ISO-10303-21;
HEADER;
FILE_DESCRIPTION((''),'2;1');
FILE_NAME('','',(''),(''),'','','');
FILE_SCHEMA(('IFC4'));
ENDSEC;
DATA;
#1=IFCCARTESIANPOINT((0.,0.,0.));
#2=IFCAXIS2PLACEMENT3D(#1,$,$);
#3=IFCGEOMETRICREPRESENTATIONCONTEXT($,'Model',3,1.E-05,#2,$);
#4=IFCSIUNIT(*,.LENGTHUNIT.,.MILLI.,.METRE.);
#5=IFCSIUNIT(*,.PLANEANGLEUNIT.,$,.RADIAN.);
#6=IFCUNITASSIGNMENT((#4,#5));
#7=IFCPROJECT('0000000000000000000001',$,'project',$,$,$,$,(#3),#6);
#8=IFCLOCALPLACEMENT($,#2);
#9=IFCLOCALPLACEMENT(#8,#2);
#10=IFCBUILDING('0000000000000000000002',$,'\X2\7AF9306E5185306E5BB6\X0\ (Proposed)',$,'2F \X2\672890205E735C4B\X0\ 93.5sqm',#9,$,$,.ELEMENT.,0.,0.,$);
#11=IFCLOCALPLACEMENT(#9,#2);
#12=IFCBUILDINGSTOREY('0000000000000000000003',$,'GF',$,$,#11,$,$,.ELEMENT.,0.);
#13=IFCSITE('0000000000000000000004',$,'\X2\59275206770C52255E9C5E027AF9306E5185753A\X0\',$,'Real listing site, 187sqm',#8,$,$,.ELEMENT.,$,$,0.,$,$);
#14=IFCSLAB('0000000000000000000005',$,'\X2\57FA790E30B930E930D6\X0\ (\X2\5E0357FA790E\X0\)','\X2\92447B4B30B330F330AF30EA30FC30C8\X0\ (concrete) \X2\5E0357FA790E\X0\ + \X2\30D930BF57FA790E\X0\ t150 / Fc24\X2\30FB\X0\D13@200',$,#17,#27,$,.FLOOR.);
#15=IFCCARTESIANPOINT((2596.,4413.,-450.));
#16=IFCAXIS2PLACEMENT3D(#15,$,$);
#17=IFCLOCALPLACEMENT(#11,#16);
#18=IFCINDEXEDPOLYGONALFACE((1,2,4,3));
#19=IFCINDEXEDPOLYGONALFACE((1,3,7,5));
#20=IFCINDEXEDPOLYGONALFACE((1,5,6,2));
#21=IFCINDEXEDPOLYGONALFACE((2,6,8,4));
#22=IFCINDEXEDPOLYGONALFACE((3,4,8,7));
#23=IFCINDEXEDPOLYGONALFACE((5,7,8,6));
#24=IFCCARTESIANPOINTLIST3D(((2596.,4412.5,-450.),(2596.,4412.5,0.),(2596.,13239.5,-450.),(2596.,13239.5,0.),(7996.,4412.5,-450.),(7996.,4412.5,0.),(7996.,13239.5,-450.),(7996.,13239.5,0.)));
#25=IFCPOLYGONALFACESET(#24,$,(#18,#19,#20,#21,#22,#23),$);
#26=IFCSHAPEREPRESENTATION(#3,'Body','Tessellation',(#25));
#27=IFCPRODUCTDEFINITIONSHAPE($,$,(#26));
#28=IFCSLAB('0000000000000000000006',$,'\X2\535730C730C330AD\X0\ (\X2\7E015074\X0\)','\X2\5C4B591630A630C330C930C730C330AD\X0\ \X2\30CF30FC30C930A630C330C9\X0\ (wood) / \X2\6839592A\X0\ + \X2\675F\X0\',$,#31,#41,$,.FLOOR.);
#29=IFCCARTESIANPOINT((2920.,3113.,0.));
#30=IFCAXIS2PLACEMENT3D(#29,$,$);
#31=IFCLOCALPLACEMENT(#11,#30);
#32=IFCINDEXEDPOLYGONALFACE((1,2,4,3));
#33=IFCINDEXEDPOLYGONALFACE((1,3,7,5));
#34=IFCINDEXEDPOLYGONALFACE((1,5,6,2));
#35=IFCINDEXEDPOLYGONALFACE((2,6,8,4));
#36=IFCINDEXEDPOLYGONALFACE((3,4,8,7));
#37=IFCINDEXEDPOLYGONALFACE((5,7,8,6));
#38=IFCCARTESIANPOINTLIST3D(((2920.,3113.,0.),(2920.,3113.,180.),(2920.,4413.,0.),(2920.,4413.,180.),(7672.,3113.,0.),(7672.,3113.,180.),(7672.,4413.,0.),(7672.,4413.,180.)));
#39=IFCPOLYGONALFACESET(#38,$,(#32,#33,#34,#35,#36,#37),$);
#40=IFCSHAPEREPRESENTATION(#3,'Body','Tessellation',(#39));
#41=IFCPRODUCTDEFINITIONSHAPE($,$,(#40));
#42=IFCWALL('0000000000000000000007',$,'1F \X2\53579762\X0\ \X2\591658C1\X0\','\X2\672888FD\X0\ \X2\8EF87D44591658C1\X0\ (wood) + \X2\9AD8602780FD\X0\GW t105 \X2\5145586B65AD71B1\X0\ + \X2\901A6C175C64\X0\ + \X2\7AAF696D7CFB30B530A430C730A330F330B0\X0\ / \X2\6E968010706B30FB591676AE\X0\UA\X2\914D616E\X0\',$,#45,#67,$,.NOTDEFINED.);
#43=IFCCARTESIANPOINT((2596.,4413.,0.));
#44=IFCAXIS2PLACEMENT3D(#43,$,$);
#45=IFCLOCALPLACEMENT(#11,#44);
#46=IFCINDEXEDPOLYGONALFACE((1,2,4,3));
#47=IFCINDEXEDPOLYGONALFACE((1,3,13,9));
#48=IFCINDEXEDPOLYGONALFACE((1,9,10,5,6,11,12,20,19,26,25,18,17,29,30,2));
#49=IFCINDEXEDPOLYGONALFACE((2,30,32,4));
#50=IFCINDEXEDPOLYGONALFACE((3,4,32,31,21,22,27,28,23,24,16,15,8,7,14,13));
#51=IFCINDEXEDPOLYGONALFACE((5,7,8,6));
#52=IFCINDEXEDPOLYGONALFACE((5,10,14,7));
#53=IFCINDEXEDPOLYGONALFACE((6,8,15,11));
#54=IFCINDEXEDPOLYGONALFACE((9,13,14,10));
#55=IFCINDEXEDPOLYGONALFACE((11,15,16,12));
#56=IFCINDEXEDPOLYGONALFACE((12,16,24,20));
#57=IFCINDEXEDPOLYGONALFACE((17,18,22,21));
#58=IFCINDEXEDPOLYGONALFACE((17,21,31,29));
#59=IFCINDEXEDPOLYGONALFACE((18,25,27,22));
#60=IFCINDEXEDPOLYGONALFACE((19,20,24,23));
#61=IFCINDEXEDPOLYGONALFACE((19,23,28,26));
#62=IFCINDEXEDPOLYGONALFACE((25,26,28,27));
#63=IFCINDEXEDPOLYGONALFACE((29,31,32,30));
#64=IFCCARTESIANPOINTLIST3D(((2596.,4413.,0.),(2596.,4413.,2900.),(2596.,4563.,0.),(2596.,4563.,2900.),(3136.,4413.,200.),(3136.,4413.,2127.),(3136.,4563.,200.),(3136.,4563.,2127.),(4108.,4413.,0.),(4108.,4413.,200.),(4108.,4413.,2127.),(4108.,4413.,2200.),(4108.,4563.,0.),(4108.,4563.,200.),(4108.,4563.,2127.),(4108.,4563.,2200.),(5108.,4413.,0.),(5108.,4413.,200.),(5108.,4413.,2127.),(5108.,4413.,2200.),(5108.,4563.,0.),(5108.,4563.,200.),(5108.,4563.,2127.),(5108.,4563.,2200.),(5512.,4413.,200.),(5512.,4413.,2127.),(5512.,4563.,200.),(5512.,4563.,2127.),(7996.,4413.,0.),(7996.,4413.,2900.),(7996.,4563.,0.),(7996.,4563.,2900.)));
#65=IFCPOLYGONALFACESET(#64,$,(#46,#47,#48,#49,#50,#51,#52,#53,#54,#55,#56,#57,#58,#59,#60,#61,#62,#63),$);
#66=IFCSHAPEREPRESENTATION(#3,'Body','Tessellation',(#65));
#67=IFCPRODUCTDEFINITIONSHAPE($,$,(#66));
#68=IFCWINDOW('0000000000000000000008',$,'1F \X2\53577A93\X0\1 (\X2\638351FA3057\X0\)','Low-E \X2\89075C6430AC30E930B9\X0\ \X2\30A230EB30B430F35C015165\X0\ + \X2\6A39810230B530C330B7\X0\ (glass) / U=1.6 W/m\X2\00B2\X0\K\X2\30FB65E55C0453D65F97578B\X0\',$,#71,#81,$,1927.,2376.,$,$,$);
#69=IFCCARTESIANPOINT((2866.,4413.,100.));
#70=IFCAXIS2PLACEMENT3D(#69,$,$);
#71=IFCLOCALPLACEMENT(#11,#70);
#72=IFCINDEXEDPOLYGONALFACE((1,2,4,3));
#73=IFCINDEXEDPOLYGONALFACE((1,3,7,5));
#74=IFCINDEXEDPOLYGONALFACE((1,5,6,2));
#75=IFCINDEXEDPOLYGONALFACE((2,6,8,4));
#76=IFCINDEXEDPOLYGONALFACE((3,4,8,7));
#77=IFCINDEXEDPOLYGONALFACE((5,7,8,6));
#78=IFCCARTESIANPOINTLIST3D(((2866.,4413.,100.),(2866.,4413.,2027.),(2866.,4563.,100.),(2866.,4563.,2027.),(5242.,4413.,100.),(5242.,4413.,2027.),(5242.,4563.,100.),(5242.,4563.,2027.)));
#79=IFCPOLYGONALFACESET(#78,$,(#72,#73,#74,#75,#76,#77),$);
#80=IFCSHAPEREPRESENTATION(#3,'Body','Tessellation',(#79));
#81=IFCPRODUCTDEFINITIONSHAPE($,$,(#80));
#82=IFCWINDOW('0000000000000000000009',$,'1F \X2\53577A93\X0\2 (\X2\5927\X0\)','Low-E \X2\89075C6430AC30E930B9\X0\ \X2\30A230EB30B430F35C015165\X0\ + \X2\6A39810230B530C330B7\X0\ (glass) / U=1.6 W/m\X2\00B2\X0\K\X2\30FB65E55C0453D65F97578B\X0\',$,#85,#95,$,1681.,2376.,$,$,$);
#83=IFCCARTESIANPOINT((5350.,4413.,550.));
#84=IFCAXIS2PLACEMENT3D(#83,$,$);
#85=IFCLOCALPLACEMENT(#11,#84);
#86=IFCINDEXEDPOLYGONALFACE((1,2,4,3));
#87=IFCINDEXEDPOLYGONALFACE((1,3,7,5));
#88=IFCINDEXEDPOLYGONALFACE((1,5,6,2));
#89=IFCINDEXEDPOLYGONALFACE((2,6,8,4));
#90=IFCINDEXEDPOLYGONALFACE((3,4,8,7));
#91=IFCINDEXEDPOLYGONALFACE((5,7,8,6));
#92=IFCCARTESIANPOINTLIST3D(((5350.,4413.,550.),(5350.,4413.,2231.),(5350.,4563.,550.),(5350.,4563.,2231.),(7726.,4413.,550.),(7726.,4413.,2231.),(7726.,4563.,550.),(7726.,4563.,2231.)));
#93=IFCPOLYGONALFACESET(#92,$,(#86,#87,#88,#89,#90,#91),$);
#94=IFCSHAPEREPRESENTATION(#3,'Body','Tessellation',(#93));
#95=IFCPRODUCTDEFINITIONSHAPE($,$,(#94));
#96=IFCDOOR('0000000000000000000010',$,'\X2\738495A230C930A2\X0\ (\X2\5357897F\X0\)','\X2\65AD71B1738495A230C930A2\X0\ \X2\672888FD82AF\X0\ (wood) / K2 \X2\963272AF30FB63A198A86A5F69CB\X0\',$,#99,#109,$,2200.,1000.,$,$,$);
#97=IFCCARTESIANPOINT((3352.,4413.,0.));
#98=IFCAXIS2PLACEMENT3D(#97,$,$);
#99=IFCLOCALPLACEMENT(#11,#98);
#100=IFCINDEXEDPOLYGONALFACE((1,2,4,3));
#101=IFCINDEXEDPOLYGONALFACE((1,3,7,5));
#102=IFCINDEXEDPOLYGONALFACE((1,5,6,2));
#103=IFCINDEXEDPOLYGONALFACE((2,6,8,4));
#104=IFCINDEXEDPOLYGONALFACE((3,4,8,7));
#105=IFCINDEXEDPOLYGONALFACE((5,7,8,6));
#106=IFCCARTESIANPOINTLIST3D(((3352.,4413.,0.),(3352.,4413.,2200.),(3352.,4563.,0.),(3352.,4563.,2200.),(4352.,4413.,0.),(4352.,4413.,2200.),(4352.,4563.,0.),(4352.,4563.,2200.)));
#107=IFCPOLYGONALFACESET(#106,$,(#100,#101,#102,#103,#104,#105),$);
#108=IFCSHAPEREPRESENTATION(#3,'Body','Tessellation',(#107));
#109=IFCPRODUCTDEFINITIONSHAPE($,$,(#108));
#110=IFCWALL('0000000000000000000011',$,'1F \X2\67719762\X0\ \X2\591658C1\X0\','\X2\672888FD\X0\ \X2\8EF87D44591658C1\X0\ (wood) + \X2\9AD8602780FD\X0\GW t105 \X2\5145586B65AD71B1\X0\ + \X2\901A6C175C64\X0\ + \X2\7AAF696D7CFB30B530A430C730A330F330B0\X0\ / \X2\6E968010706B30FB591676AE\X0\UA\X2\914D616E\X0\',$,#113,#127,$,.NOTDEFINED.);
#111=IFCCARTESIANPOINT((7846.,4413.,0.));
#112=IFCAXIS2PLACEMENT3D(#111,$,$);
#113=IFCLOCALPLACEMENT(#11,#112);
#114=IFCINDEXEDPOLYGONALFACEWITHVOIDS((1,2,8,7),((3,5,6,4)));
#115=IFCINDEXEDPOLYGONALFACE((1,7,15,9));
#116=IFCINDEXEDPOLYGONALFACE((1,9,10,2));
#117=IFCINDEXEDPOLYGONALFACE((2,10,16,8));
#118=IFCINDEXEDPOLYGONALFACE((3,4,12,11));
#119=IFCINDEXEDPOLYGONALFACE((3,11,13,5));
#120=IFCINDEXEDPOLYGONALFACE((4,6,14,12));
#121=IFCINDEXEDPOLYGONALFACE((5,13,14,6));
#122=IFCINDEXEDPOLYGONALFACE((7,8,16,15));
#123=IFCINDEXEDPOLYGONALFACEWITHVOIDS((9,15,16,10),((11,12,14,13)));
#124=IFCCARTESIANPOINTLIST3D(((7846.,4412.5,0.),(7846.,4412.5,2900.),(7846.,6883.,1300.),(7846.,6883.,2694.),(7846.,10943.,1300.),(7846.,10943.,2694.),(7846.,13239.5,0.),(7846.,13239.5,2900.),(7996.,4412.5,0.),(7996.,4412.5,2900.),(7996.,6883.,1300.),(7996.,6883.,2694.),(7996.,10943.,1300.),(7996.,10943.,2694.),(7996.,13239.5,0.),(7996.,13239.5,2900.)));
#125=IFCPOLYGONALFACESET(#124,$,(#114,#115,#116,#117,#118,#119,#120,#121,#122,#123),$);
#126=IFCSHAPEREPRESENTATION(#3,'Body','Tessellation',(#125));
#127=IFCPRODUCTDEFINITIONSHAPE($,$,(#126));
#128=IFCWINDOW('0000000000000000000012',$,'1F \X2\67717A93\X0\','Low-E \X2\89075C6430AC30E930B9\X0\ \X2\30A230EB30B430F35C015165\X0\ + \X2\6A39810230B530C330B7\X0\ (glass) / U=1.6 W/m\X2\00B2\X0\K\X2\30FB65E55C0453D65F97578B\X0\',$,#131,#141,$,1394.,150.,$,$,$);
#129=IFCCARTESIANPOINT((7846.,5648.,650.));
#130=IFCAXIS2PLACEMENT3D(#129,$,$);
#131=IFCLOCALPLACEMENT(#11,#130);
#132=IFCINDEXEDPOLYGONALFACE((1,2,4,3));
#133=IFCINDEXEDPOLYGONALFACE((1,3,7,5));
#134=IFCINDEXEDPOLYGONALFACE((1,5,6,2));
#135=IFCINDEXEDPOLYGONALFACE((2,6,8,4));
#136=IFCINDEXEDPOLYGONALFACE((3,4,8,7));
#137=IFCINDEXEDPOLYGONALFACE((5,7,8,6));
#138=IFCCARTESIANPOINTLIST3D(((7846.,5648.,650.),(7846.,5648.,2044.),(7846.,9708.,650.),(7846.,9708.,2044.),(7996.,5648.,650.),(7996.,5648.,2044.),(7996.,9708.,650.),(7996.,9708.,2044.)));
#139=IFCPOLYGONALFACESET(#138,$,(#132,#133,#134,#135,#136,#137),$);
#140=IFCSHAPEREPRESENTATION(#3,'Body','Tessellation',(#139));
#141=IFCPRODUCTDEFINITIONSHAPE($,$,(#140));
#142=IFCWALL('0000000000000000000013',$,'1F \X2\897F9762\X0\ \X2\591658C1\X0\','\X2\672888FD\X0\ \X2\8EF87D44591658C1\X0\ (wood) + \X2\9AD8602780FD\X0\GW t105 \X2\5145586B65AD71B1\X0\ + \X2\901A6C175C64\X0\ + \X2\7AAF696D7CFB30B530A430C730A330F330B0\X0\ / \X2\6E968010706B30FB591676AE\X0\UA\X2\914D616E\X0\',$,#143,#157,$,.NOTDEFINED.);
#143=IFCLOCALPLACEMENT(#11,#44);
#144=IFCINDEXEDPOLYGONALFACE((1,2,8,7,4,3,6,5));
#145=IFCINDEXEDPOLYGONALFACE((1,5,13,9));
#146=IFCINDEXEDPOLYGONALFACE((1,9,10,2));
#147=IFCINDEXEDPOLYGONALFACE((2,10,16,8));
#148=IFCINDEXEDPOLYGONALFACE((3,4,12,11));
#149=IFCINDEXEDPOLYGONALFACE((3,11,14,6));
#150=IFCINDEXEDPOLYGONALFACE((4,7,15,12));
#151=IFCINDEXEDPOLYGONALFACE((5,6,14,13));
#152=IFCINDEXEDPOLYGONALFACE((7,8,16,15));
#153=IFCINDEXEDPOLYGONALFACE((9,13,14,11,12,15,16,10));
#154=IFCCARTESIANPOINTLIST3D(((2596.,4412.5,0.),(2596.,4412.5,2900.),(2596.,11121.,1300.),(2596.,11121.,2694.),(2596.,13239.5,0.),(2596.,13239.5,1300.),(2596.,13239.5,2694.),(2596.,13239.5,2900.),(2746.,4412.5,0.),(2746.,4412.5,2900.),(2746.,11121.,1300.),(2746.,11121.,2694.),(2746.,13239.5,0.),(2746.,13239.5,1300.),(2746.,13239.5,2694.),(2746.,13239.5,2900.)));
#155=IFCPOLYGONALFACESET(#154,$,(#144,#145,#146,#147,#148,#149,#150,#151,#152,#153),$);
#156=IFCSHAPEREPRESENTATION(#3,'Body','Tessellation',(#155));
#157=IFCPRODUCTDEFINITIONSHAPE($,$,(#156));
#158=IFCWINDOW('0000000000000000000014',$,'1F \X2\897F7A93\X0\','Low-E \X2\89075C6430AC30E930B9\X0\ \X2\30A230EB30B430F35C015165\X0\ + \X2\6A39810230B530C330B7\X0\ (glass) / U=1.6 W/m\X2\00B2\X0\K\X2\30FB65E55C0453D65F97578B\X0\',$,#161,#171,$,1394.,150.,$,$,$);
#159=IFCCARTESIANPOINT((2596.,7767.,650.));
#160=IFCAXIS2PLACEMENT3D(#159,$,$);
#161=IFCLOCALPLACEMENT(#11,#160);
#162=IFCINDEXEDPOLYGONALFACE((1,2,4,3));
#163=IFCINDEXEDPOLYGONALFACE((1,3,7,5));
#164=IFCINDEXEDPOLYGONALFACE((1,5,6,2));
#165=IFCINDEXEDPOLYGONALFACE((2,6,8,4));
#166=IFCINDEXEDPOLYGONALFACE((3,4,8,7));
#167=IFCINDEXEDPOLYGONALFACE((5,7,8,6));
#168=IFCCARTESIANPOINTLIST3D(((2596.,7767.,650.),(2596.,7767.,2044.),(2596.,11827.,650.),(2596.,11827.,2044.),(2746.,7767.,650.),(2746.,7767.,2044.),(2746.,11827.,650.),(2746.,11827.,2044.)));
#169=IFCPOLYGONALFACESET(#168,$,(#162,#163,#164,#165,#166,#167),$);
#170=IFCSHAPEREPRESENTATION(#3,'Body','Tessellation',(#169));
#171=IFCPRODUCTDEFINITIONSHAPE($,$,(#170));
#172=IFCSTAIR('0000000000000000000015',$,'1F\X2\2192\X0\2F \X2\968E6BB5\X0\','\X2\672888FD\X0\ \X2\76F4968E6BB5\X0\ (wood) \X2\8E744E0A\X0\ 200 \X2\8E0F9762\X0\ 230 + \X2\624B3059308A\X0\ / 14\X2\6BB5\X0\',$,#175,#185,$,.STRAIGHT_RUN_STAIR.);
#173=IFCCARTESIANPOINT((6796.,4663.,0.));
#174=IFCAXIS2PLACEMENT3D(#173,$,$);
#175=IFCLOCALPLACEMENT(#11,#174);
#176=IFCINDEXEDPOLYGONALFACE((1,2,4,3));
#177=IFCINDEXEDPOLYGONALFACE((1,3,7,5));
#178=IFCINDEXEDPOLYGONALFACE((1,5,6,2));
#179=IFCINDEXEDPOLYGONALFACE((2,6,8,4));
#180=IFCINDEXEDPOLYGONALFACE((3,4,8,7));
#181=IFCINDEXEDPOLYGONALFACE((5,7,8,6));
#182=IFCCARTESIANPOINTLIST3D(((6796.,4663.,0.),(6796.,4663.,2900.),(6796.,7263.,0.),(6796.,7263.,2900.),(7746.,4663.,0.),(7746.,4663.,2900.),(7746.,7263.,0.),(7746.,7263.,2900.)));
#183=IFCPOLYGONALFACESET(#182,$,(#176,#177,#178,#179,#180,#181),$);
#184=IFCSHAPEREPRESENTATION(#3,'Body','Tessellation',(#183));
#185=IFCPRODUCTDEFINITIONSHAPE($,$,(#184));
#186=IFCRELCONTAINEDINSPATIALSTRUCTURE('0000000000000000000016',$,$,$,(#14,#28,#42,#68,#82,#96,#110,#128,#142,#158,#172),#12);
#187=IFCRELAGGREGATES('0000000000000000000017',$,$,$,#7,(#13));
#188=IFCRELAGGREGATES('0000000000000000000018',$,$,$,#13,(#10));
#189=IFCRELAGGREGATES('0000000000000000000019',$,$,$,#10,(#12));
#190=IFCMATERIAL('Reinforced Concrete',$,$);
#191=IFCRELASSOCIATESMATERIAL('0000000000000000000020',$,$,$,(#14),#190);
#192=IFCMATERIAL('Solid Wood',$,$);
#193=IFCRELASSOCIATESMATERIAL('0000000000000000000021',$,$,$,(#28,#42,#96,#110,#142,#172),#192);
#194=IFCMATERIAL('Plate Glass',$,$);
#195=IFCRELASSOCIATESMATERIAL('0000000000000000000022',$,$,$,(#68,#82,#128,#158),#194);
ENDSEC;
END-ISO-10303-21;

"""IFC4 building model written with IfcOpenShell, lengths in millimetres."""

from ifc_helpers import new_model, si_unit, frame, frame_2d, origin, place, context, project, spatial, rectangle, extrude, material, element, fill, save


model = new_model("IFC4")

# Units and contexts
model_context = context("Model", 3, precision=1e-05, world=origin())
ifc_project = project(units=[si_unit("LENGTHUNIT", "METRE", prefix="MILLI"), si_unit("PLANEANGLEUNIT", "RADIAN")], contexts=[model_context])

# Site, building, storey
site_placement = place(None, origin())
site = spatial("IfcSite", under=ifc_project, at=site_placement, Name="大分県別府市竹の内町", ObjectType="Real listing site, 187sqm", CompositionType="ELEMENT", RefElevation=0.0)
building_placement = place(site_placement, origin())
building = spatial("IfcBuilding", under=site, at=building_placement, Name="竹の内の家 (Proposed)", ObjectType="2F 木造平屋 93.5sqm", CompositionType="ELEMENT", ElevationOfRefHeight=0.0, ElevationOfTerrain=0.0)
storey_placement = place(building_placement, origin())
storey = spatial("IfcBuildingStorey", under=building, at=storey_placement, Name="GF", CompositionType="ELEMENT", Elevation=0.0)

# Slabs
ifc_material_1 = material(Name="Reinforced Concrete")
slab_1_placement = place(storey_placement, frame((2596.0, 4413.0, -450.0)))
element("IfcSlab", 1, at=slab_1_placement, inside=storey, material=ifc_material_1, Name="基礎スラブ (布基礎)", Description="鉄筋コンクリート (concrete) 布基礎 + ベタ基礎 t150 / Fc24・D13@200", PredefinedType="FLOOR", context=model_context, shape_type="SweptSolid", body=[
    extrude(rectangle(XDim=5400.0, YDim=8827.0, at=frame_2d((2700.0, 4413.0))), frame((2596.0, 4413.0, -450.0)), (0.0, 0.0, 1.0), 450.0),
])
ifc_material_2 = material(Name="Solid Wood")
slab_2_placement = place(storey_placement, frame((2920.0, 3113.0, 0.0)))
element("IfcSlab", 2, at=slab_2_placement, inside=storey, material=ifc_material_2, Name="南デッキ (縁側)", Description="屋外ウッドデッキ ハードウッド (wood) / 根太 + 束", PredefinedType="FLOOR", context=model_context, shape_type="SweptSolid", body=[
    extrude(rectangle(XDim=4752.0, YDim=1300.0, at=frame_2d((2376.0, 650.0))), frame((2920.0, 3113.0, 0.0)), (0.0, 0.0, 1.0), 180.0),
])

# Wall, openings, windows, door
wall_1_placement = place(storey_placement, frame((2596.0, 4413.0, 0.0)))
wall_1 = element("IfcWall", 3, at=wall_1_placement, inside=storey, material=ifc_material_2, Name="1F 南面 外壁", Description="木製 軸組外壁 (wood) + 高性能GW t105 充填断熱 + 通気層 + 窯業系サイディング / 準耐火・外皮UA配慮", PredefinedType="NOTDEFINED", context=model_context, shape_type="SweptSolid", body=[
    extrude(rectangle(XDim=5400.0, YDim=150.0, at=frame_2d((2700.0, 75.0))), frame((2596.0, 4413.0, 0.0)), (0.0, 0.0, 1.0), 2900.0),
])
opening_1_placement = place(storey_placement, frame((2866.0, 4413.0, 100.0)))
opening_1 = element("IfcOpeningElement", 4, at=opening_1_placement, cuts=wall_1, PredefinedType="NOTDEFINED", context=model_context, shape_type="SweptSolid", body=[
    extrude(rectangle(XDim=2376.0, YDim=150.0, at=frame_2d((1188.0, 75.0))), frame((2866.0, 4413.0, 100.0)), (0.0, 0.0, 1.0), 1927.0),
])
opening_2_placement = place(storey_placement, frame((5350.0, 4413.0, 550.0)))
opening_2 = element("IfcOpeningElement", 5, at=opening_2_placement, cuts=wall_1, PredefinedType="NOTDEFINED", context=model_context, shape_type="SweptSolid", body=[
    extrude(rectangle(XDim=2376.0, YDim=150.0, at=frame_2d((1188.0, 75.0))), frame((5350.0, 4413.0, 550.0)), (0.0, 0.0, 1.0), 1681.0),
])
opening_3_placement = place(storey_placement, frame((3352.0, 4413.0, 0.0)))
opening_3 = element("IfcOpeningElement", 6, at=opening_3_placement, cuts=wall_1, PredefinedType="NOTDEFINED", context=model_context, shape_type="SweptSolid", body=[
    extrude(rectangle(XDim=1000.0, YDim=150.0, at=frame_2d((500.0, 75.0))), frame((3352.0, 4413.0, 0.0)), (0.0, 0.0, 1.0), 2200.0),
])
ifc_material_3 = material(Name="Plate Glass")
window_1_placement = place(storey_placement, frame((2866.0, 4413.0, 100.0)))
window_1 = element("IfcWindow", 7, at=window_1_placement, inside=storey, material=ifc_material_3, Name="1F 南窓1 (掃出し)", Description="Low-E 複層ガラス アルゴン封入 + 樹脂サッシ (glass) / U=1.6 W/m²K・日射取得型", OverallHeight=1927.0, OverallWidth=2376.0, context=model_context, shape_type="SweptSolid", body=[
    extrude(rectangle(XDim=2376.0, YDim=150.0, at=frame_2d((1188.0, 75.0))), frame((2866.0, 4413.0, 100.0)), (0.0, 0.0, 1.0), 1927.0),
])
fill(opening_1, window_1)
window_2_placement = place(storey_placement, frame((5350.0, 4413.0, 550.0)))
window_2 = element("IfcWindow", 8, at=window_2_placement, inside=storey, material=ifc_material_3, Name="1F 南窓2 (大)", Description="Low-E 複層ガラス アルゴン封入 + 樹脂サッシ (glass) / U=1.6 W/m²K・日射取得型", OverallHeight=1681.0, OverallWidth=2376.0, context=model_context, shape_type="SweptSolid", body=[
    extrude(rectangle(XDim=2376.0, YDim=150.0, at=frame_2d((1188.0, 75.0))), frame((5350.0, 4413.0, 550.0)), (0.0, 0.0, 1.0), 1681.0),
])
fill(opening_2, window_2)
door_placement = place(storey_placement, frame((3352.0, 4413.0, 0.0)))
door = element("IfcDoor", 9, at=door_placement, inside=storey, material=ifc_material_2, Name="玄関ドア (南西)", Description="断熱玄関ドア 木製芯 (wood) / K2 防犯・採風機構", OverallHeight=2200.0, OverallWidth=1000.0, context=model_context, shape_type="SweptSolid", body=[
    extrude(rectangle(XDim=1000.0, YDim=150.0, at=frame_2d((500.0, 75.0))), frame((3352.0, 4413.0, 0.0)), (0.0, 0.0, 1.0), 2200.0),
])
fill(opening_3, door)

# Walls, openings, windows
wall_2_placement = place(storey_placement, frame((7846.0, 4413.0, 0.0)))
wall_2 = element("IfcWall", 10, at=wall_2_placement, inside=storey, material=ifc_material_2, Name="1F 東面 外壁", Description="木製 軸組外壁 (wood) + 高性能GW t105 充填断熱 + 通気層 + 窯業系サイディング / 準耐火・外皮UA配慮", PredefinedType="NOTDEFINED", context=model_context, shape_type="SweptSolid", body=[
    extrude(rectangle(XDim=150.0, YDim=8827.0, at=frame_2d((75.0, 4413.0))), frame((7846.0, 4413.0, 0.0)), (0.0, 0.0, 1.0), 2900.0),
])
opening_4_placement = place(storey_placement, frame((7846.0, 5648.0, 650.0)))
opening_4 = element("IfcOpeningElement", 11, at=opening_4_placement, cuts=wall_2, PredefinedType="NOTDEFINED", context=model_context, shape_type="SweptSolid", body=[
    extrude(rectangle(XDim=150.0, YDim=4060.0, at=frame_2d((75.0, 2030.0))), frame((7846.0, 5648.0, 650.0)), (0.0, 0.0, 1.0), 1394.0),
])
window_3_placement = place(storey_placement, frame((7846.0, 5648.0, 650.0)))
window_3 = element("IfcWindow", 12, at=window_3_placement, inside=storey, material=ifc_material_3, Name="1F 東窓", Description="Low-E 複層ガラス アルゴン封入 + 樹脂サッシ (glass) / U=1.6 W/m²K・日射取得型", OverallHeight=1394.0, OverallWidth=150.0, context=model_context, shape_type="SweptSolid", body=[
    extrude(rectangle(XDim=150.0, YDim=4060.0, at=frame_2d((75.0, 2030.0))), frame((7846.0, 5648.0, 650.0)), (0.0, 0.0, 1.0), 1394.0),
])
fill(opening_4, window_3)
wall_3_placement = place(storey_placement, frame((2596.0, 4413.0, 0.0)))
wall_3 = element("IfcWall", 13, at=wall_3_placement, inside=storey, material=ifc_material_2, Name="1F 西面 外壁", Description="木製 軸組外壁 (wood) + 高性能GW t105 充填断熱 + 通気層 + 窯業系サイディング / 準耐火・外皮UA配慮", PredefinedType="NOTDEFINED", context=model_context, shape_type="SweptSolid", body=[
    extrude(rectangle(XDim=150.0, YDim=8827.0, at=frame_2d((75.0, 4413.0))), frame((2596.0, 4413.0, 0.0)), (0.0, 0.0, 1.0), 2900.0),
])
opening_5_placement = place(storey_placement, frame((2596.0, 7767.0, 650.0)))
opening_5 = element("IfcOpeningElement", 14, at=opening_5_placement, cuts=wall_3, PredefinedType="NOTDEFINED", context=model_context, shape_type="SweptSolid", body=[
    extrude(rectangle(XDim=150.0, YDim=4060.0, at=frame_2d((75.0, 2030.0))), frame((2596.0, 7767.0, 650.0)), (0.0, 0.0, 1.0), 1394.0),
])
window_4_placement = place(storey_placement, frame((2596.0, 7767.0, 650.0)))
window_4 = element("IfcWindow", 15, at=window_4_placement, inside=storey, material=ifc_material_3, Name="1F 西窓", Description="Low-E 複層ガラス アルゴン封入 + 樹脂サッシ (glass) / U=1.6 W/m²K・日射取得型", OverallHeight=1394.0, OverallWidth=150.0, context=model_context, shape_type="SweptSolid", body=[
    extrude(rectangle(XDim=150.0, YDim=4060.0, at=frame_2d((75.0, 2030.0))), frame((2596.0, 7767.0, 650.0)), (0.0, 0.0, 1.0), 1394.0),
])
fill(opening_5, window_4)

# Stair
stair_placement = place(storey_placement, frame((6796.0, 4663.0, 0.0)))
element("IfcStair", 16, at=stair_placement, inside=storey, material=ifc_material_2, Name="1F→2F 階段", Description="木製 直階段 (wood) 蹴上 200 踏面 230 + 手すり / 14段", PredefinedType="STRAIGHT_RUN_STAIR", context=model_context, shape_type="SweptSolid", body=[
    extrude(rectangle(XDim=950.0, YDim=2600.0, at=frame_2d((475.0, 1300.0))), frame((6796.0, 4663.0, 0.0)), (0.0, 0.0, 1.0), 2900.0),
])

save(model, "model.ifc")
